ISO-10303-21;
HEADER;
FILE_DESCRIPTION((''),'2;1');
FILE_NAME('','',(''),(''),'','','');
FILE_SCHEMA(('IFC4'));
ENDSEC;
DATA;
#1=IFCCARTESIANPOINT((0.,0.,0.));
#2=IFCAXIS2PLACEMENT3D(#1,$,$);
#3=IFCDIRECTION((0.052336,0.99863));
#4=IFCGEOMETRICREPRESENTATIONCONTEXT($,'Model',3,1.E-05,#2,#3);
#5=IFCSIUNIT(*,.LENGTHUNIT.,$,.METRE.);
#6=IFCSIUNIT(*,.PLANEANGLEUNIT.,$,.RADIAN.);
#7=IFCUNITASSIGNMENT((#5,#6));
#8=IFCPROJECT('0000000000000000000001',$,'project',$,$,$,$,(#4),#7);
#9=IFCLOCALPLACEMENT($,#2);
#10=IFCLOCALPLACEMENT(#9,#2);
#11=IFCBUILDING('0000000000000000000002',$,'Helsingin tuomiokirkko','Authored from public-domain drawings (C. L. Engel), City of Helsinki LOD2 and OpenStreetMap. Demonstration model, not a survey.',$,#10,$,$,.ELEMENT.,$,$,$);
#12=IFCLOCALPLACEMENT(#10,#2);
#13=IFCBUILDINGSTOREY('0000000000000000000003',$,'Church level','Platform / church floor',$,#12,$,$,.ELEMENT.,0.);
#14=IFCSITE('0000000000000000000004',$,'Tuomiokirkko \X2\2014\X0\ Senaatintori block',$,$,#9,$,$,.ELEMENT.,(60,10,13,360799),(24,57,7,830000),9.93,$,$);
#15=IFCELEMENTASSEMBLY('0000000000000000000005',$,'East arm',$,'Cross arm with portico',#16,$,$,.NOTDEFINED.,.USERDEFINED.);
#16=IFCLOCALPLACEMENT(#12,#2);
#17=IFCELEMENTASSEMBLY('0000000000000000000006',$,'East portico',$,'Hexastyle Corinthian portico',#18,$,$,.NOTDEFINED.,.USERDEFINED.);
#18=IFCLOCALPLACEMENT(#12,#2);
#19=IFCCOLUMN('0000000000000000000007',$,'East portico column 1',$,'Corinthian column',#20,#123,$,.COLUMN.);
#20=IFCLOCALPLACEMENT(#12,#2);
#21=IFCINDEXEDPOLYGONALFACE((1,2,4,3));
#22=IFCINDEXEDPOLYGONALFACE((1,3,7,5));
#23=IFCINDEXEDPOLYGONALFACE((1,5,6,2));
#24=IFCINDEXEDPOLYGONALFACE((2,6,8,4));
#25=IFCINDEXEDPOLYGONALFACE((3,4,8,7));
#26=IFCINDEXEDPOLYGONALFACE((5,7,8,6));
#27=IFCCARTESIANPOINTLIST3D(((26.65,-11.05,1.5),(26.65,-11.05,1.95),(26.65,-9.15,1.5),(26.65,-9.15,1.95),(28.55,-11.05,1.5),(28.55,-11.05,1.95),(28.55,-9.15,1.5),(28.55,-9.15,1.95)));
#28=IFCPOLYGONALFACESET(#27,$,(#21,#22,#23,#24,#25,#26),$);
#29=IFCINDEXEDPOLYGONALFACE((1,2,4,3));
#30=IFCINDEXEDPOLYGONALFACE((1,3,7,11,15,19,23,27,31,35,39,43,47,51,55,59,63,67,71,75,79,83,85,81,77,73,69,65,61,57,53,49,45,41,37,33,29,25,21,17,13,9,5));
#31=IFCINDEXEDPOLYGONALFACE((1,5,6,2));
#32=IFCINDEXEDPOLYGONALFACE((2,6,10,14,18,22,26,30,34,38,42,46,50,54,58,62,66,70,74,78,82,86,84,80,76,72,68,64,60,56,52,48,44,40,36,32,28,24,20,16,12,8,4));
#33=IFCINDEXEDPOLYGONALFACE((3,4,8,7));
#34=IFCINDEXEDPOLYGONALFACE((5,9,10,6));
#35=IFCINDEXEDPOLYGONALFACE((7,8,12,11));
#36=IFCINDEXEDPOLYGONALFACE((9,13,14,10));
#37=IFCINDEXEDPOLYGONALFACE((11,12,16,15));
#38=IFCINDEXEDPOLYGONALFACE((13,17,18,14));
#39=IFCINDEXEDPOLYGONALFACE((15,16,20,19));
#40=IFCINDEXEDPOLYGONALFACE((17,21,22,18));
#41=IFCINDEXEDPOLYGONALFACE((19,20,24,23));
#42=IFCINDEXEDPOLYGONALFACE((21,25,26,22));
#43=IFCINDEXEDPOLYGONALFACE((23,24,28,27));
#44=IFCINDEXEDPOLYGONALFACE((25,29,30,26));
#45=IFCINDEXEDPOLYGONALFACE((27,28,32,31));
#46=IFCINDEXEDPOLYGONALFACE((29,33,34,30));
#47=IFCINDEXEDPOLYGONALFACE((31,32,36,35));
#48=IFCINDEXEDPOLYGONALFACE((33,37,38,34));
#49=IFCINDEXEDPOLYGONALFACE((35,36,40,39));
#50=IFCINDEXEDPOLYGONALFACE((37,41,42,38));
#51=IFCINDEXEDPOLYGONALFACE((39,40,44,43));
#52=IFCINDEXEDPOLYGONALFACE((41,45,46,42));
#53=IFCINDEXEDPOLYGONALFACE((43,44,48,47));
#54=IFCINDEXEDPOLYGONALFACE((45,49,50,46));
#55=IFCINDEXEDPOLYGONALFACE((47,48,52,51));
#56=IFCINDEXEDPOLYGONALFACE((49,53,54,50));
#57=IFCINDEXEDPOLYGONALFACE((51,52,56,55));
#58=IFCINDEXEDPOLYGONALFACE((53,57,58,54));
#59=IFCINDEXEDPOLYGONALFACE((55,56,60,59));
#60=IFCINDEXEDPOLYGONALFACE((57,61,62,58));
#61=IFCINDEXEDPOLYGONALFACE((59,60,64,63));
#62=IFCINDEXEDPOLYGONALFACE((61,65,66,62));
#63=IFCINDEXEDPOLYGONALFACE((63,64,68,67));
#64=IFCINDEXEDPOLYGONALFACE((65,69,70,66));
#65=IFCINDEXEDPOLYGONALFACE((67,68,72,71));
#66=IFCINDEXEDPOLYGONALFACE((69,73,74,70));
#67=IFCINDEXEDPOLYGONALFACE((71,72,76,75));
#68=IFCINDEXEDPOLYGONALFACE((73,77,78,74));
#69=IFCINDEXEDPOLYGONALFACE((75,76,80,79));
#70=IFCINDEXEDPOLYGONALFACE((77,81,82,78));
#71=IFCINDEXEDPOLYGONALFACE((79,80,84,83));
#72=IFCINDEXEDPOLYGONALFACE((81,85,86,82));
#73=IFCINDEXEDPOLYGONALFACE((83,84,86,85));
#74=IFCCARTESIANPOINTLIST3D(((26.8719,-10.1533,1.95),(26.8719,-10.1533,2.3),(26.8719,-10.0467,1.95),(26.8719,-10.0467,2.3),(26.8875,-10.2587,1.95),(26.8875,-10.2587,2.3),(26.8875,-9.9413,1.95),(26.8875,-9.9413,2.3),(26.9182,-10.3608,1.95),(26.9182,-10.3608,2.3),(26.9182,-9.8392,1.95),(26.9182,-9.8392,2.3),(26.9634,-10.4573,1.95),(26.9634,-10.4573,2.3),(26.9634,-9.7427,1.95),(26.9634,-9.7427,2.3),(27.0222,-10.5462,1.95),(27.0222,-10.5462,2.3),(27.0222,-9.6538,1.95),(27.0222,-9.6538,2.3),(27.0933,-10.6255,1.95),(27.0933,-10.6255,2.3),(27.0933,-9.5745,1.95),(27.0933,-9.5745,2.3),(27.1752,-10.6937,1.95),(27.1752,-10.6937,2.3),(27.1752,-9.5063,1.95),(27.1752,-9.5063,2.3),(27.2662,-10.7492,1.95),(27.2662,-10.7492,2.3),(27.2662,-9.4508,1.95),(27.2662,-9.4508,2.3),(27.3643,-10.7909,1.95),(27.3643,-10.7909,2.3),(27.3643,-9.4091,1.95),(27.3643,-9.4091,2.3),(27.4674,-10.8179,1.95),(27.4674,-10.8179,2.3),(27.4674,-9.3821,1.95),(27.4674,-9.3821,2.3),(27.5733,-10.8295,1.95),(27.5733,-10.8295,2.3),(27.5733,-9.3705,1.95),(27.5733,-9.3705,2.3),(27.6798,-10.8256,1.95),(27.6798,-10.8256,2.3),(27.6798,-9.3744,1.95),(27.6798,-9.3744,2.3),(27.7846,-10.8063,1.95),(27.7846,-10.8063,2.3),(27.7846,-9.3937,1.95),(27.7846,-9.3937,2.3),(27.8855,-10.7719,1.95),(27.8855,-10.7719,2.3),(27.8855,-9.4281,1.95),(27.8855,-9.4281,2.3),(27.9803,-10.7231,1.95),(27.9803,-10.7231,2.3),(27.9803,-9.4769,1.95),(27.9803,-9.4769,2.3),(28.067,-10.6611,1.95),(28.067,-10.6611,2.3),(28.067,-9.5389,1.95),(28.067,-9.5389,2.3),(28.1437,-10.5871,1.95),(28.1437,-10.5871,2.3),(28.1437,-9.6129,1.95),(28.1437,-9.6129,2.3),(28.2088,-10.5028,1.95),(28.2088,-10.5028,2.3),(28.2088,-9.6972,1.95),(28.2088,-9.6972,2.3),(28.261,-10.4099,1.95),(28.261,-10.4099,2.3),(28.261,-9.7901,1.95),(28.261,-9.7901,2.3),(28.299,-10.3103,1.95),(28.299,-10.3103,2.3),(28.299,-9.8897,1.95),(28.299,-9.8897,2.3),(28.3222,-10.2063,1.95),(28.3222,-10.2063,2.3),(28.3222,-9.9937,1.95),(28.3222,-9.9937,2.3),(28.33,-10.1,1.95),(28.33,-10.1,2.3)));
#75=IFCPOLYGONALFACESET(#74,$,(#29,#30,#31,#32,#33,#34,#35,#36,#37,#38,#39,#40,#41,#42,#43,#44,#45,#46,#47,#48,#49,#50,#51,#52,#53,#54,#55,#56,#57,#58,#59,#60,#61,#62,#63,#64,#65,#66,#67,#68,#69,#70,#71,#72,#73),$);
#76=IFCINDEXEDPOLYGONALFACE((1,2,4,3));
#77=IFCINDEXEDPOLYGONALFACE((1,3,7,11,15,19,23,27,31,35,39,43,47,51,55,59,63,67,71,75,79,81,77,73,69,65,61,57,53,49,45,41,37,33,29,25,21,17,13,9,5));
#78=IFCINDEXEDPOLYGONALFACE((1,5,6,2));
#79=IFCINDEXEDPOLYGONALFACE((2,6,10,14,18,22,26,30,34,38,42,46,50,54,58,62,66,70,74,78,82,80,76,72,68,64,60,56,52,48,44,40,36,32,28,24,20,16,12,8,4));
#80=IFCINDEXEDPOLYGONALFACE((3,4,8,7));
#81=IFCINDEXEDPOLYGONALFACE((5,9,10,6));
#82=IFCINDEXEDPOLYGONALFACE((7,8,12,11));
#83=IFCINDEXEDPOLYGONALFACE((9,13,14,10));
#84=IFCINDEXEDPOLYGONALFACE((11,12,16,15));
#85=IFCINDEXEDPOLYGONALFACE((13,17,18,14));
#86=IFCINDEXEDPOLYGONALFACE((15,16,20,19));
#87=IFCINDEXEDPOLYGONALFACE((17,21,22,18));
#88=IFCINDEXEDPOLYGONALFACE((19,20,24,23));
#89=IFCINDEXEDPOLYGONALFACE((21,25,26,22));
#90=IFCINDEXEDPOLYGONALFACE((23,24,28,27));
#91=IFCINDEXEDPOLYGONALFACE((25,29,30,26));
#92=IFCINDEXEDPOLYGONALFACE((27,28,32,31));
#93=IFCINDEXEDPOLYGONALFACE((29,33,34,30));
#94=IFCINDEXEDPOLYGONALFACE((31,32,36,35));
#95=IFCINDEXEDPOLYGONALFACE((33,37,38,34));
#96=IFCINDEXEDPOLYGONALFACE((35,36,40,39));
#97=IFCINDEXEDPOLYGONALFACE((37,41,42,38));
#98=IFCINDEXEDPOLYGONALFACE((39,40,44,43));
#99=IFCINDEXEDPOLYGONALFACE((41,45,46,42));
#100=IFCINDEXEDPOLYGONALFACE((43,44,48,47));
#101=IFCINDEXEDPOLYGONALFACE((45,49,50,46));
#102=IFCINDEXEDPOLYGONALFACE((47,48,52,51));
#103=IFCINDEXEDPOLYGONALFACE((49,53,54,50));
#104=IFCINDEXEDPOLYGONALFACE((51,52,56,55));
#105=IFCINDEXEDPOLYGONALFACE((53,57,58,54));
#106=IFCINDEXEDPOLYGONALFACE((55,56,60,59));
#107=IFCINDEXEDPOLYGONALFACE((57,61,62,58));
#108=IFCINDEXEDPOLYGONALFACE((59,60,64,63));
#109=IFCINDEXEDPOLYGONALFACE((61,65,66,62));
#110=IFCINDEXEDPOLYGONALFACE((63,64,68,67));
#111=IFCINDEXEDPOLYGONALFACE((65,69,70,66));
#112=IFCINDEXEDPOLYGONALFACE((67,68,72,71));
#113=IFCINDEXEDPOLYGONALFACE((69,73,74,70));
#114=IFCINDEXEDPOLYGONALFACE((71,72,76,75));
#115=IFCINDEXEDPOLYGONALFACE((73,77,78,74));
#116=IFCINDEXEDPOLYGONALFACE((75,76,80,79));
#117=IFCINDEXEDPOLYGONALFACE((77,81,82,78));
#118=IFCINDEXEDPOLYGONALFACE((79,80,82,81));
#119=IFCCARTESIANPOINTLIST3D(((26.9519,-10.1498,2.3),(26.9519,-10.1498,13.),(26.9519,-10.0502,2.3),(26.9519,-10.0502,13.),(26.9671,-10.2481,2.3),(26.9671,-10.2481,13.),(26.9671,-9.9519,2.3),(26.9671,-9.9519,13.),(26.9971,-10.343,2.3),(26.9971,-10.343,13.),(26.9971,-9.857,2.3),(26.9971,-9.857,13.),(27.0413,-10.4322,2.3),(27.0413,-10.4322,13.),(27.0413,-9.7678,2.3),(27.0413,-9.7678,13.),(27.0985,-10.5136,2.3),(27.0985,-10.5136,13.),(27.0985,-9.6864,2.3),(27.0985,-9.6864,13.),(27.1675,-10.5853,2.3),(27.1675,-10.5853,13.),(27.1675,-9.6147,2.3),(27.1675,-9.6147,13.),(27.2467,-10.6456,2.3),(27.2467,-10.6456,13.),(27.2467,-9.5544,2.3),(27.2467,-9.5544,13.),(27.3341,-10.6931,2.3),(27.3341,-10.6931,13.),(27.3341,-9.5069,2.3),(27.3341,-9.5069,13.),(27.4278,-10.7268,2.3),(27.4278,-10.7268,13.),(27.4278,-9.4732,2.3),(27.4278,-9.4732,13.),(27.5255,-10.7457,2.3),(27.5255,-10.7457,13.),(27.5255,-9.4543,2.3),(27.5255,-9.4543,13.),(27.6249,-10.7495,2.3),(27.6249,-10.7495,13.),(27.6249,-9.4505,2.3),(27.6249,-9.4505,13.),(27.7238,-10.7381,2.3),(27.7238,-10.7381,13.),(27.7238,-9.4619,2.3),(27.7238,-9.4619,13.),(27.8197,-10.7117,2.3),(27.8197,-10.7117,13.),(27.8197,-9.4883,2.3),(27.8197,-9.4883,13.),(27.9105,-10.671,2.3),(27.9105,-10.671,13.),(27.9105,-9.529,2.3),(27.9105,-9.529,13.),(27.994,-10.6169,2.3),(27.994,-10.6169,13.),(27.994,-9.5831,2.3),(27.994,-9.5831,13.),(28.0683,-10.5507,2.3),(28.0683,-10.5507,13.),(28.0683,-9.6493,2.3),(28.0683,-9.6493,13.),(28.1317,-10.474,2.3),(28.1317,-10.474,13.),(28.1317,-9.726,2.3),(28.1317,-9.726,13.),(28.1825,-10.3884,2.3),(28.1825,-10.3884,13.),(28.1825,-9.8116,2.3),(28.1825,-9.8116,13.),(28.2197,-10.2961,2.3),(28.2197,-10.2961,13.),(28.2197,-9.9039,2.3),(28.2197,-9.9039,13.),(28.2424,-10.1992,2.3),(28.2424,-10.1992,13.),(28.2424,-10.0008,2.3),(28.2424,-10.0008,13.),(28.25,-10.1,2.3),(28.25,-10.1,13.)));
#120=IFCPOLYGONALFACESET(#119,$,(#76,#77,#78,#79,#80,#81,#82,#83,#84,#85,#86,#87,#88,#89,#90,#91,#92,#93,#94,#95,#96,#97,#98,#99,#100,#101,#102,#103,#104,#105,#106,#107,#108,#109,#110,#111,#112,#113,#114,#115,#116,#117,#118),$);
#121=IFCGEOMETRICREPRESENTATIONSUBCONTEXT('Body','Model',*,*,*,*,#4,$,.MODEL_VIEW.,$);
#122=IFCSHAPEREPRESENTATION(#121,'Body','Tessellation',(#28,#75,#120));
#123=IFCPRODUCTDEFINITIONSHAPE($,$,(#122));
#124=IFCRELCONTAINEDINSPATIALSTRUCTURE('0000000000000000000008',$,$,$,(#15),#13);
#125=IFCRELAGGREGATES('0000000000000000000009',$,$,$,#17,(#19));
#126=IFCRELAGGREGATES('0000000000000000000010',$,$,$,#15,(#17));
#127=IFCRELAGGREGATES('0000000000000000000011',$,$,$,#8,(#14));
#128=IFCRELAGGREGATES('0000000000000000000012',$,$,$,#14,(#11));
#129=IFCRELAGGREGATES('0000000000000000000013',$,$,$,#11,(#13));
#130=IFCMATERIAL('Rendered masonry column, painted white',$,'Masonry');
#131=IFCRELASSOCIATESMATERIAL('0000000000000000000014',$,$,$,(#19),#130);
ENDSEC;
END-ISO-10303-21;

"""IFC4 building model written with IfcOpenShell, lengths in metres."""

from ifc_helpers import new_model, si_unit, direction, frame, origin, origin_2d_with_axis, place, context, subcontext, project, spatial, rectangle, circle, extrude, material, element, aggregate, save


model = new_model("IFC4")

# Units and contexts
model_context = context("Model", 3, precision=1e-05, world=origin(), true_north=direction((0.052336, 0.99863)))
body_context = subcontext(model_context, "Body", "Model", "MODEL_VIEW")
ifc_project = project(units=[si_unit("LENGTHUNIT", "METRE"), si_unit("PLANEANGLEUNIT", "RADIAN")], contexts=[model_context])

# Site, building, storey
site_placement = place(None, origin())
site = spatial("IfcSite", under=ifc_project, at=site_placement, Name="Tuomiokirkko — Senaatintori block", CompositionType="ELEMENT", RefLatitude=(60, 10, 13, 360799), RefLongitude=(24, 57, 7, 830000), RefElevation=9.93)
building_placement = place(site_placement, origin())
building = spatial("IfcBuilding", under=site, at=building_placement, Name="Helsingin tuomiokirkko", Description="Authored from public-domain drawings (C. L. Engel), City of Helsinki LOD2 and OpenStreetMap. Demonstration model, not a survey.", CompositionType="ELEMENT")
storey_placement = place(building_placement, origin())
storey = spatial("IfcBuildingStorey", under=building, at=storey_placement, Name="Church level", Description="Platform / church floor", CompositionType="ELEMENT", Elevation=0.0)

# Shared definitions
ifc_material_1 = material(Name="Rendered masonry column, painted white", Category="Masonry")

# Element assemblies, column
assembly_1_placement = place(building_placement, origin())
assembly_1 = element("IfcElementAssembly", 1, at=assembly_1_placement, inside=storey, Name="East arm", ObjectType="Cross arm with portico", AssemblyPlace="NOTDEFINED", PredefinedType="USERDEFINED")
assembly_2_placement = place(building_placement, origin())
assembly_2 = element("IfcElementAssembly", 2, at=assembly_2_placement, Name="East portico", ObjectType="Hexastyle Corinthian portico", AssemblyPlace="NOTDEFINED", PredefinedType="USERDEFINED")
column_1_placement = place(building_placement, origin())
column_1 = element("IfcColumn", 3, at=column_1_placement, material=ifc_material_1, Name="East portico column 1", ObjectType="Corinthian column", PredefinedType="COLUMN", context=body_context, shape_type="SweptSolid", body=[
    extrude(rectangle(XDim=1.9, YDim=1.9, at=origin_2d_with_axis()), frame((27.6, -10.1, 1.5)), (0.0, 0.0, 1.0), 0.45),
    extrude(circle(Radius=0.73, at=origin_2d_with_axis()), frame((27.6, -10.1, 1.95)), (0.0, 0.0, 1.0), 0.35),
    extrude(circle(Radius=0.65, at=origin_2d_with_axis()), frame((27.6, -10.1, 2.3)), (0.0, 0.0, 1.0), 10.7),
])

aggregate(assembly_2, [column_1])

aggregate(assembly_1, [assembly_2])

save(model, "model.ifc")
